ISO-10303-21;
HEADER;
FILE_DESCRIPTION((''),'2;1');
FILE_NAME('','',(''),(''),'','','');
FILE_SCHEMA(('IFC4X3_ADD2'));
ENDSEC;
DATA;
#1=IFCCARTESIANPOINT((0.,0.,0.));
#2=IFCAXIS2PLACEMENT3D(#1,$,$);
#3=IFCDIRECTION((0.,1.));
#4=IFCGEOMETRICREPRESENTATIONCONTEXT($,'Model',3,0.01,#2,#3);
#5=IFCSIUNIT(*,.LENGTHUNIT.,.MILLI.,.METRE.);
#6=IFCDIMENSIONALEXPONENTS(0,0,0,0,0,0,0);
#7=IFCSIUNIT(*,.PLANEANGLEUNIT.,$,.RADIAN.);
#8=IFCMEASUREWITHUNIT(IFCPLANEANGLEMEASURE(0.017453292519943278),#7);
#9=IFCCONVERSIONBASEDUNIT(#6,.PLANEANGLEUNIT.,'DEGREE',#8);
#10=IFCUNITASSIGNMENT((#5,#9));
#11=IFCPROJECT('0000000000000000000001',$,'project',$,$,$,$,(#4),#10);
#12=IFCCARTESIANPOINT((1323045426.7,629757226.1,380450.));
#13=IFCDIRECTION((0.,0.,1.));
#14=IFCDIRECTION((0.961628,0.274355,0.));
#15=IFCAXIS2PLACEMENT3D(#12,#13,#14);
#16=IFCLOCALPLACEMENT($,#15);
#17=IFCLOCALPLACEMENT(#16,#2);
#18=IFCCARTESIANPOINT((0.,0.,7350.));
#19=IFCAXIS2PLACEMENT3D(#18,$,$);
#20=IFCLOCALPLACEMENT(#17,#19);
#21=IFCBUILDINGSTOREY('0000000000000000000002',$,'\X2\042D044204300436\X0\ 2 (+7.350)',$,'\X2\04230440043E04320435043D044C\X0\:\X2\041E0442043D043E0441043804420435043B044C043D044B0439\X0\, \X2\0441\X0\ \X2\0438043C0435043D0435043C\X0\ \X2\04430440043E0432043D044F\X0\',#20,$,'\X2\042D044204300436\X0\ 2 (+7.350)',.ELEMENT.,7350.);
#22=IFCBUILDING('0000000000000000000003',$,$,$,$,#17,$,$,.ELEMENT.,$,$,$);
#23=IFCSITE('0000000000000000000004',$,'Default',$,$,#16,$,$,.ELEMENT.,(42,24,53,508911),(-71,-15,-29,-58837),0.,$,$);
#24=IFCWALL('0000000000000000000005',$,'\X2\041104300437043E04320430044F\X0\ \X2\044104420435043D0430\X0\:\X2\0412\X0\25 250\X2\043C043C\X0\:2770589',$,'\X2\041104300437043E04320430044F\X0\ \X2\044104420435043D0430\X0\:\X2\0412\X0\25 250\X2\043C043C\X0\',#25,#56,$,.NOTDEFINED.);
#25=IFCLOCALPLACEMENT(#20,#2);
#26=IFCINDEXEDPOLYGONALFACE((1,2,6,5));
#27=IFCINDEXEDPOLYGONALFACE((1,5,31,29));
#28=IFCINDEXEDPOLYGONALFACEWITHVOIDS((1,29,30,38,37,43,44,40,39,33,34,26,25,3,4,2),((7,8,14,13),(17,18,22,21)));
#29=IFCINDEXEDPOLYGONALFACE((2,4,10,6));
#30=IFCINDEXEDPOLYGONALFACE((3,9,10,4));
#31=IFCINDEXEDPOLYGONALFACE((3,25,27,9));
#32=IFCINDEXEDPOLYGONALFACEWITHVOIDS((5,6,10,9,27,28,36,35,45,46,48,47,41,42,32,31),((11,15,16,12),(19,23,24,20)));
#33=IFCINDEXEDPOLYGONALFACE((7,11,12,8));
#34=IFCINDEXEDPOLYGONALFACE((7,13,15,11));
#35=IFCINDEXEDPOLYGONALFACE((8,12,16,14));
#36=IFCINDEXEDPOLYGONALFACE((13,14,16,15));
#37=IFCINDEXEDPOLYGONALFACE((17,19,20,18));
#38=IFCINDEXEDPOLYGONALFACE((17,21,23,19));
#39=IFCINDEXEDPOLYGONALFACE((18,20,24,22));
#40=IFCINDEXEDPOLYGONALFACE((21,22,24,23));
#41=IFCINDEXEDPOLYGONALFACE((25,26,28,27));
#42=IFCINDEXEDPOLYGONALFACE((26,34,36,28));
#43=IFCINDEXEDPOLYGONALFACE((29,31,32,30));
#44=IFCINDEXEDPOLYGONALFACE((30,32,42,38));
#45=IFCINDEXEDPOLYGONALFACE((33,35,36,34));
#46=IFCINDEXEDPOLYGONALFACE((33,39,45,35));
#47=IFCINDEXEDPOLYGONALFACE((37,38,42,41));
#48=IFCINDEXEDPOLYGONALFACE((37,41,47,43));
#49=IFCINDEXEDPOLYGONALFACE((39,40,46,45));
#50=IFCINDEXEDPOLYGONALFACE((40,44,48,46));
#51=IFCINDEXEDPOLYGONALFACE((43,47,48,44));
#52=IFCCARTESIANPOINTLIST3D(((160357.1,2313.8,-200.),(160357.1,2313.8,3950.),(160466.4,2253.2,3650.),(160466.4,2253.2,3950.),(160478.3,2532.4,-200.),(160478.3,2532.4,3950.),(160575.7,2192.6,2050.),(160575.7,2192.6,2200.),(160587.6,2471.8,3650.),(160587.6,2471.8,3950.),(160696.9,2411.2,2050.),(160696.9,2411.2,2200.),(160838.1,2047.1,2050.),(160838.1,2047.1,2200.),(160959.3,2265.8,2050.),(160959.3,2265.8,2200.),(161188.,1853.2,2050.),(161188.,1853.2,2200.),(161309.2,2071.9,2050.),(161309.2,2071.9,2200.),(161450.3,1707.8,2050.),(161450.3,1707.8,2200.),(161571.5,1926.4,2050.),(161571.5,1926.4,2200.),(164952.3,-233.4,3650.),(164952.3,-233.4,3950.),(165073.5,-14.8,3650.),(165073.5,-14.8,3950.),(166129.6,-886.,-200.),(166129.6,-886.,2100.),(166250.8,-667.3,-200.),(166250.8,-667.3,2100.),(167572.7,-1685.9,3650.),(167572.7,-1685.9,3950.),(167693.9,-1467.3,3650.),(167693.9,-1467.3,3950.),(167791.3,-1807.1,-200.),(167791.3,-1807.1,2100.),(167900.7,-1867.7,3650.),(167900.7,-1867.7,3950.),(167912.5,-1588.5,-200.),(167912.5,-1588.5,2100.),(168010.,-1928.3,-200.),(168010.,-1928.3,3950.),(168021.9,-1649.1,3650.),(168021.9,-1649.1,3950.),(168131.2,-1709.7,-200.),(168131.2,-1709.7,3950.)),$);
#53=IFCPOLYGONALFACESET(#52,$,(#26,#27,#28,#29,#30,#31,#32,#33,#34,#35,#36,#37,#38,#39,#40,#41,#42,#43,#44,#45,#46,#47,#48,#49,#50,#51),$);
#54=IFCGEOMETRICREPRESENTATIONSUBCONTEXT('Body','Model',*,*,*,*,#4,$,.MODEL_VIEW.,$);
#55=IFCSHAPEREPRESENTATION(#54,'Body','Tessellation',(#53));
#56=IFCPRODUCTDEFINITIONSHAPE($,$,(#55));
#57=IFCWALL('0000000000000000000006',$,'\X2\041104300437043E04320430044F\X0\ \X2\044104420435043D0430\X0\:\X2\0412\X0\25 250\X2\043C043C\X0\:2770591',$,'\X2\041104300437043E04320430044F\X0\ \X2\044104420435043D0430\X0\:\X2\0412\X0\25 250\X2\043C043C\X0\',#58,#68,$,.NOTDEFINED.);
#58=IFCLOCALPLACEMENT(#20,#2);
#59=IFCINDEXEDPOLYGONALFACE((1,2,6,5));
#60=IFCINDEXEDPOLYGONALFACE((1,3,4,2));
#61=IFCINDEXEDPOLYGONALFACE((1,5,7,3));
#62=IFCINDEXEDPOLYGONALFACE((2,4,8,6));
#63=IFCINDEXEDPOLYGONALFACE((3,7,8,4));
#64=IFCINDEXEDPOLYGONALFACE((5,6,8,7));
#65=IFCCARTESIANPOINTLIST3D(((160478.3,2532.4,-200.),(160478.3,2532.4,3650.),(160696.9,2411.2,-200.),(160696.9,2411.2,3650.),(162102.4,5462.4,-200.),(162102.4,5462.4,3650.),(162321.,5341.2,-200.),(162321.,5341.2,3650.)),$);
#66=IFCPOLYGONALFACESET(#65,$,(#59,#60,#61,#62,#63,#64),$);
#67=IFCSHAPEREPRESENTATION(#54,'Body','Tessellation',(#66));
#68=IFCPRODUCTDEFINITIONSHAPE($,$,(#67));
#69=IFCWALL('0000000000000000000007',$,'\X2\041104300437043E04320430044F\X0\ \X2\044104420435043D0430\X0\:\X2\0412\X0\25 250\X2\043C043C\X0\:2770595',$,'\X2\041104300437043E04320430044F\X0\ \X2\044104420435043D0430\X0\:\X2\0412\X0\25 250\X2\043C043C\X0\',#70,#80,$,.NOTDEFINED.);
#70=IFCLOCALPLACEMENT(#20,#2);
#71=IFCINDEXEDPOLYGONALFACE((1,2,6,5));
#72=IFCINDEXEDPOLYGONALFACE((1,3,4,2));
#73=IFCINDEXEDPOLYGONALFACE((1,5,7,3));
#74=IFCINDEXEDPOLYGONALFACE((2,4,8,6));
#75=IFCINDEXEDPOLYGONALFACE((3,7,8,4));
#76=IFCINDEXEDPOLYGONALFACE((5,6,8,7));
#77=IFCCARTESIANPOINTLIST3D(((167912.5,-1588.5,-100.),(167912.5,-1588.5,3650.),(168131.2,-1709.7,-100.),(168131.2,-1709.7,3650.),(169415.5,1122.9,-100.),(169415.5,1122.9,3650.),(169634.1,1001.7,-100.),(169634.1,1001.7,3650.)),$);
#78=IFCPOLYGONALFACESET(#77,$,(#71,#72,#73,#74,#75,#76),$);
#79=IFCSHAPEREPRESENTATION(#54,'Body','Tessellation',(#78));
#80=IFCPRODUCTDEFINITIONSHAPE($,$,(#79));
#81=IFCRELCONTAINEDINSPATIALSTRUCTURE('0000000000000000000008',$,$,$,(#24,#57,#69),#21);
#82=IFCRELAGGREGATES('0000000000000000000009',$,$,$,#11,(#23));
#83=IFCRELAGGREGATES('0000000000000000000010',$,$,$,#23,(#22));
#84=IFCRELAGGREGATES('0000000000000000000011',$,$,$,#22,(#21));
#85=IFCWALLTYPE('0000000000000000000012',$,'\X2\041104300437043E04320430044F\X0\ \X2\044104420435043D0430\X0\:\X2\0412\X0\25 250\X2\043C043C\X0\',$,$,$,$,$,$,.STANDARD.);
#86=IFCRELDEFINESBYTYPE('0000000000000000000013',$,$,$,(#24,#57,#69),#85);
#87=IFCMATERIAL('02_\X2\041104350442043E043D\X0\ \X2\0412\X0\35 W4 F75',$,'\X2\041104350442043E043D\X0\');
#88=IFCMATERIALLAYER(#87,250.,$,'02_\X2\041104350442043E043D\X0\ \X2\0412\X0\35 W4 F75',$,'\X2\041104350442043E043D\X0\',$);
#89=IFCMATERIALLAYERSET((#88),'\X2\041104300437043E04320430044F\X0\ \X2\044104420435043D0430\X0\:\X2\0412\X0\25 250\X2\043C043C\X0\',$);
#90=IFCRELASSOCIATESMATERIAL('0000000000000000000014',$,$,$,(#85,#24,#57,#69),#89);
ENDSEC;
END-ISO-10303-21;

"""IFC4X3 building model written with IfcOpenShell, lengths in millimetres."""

from ifc_helpers import new_model, entity, si_unit, converted_unit, direction, frame, frame_2d, origin, place, context, subcontext, project, spatial, polyline, rectangle, extrude, clip, bounded_halfspace, material, layer, layer_set, type_object, element, save


model = new_model("IFC4X3")

# Units and contexts
model_context = context("Model", 3, precision=0.01, world=origin(), true_north=direction((0.0, 1.0)))
body_context = subcontext(model_context, "Body", "Model", "MODEL_VIEW")
ifc_project = project(units=[si_unit("LENGTHUNIT", "METRE", prefix="MILLI"), converted_unit("PLANEANGLEUNIT", "DEGREE", entity("IfcPlaneAngleMeasure", 0.017453292519943278), si_unit("PLANEANGLEUNIT", "RADIAN"), dimensions=[0, 0, 0, 0, 0, 0, 0])], contexts=[model_context])

# Site, building, storey
site_placement = place(None, frame((1323045426.7, 629757226.1, 380450.0), z_axis=(0.0, 0.0, 1.0), x_axis=(0.961628, 0.274355, 0.0)))
site = spatial("IfcSite", under=ifc_project, at=site_placement, Name="Default", CompositionType="ELEMENT", RefLatitude=(42, 24, 53, 508911), RefLongitude=(-71, -15, -29, -58837), RefElevation=0.0)
building_placement = place(site_placement, origin())
building = spatial("IfcBuilding", under=site, at=building_placement, CompositionType="ELEMENT")
storey_placement = place(building_placement, frame((0.0, 0.0, 7350.0)))
storey = spatial("IfcBuildingStorey", under=building, at=storey_placement, Name="Этаж 2 (+7.350)", ObjectType="Уровень:Относительный, с именем уровня", LongName="Этаж 2 (+7.350)", CompositionType="ELEMENT", Elevation=7350.0)

# Shared definitions
ifc_material = material(Name="02_Бетон В35 W4 F75", Category="Бетон")

# Wall, openings
ifc_layer = layer(ifc_material, 250.0, Name="02_Бетон В35 W4 F75", Category="Бетон")
ifc_layer_set = layer_set([ifc_layer], Name="Базовая стена:В25 250мм")
wall_type = type_object("IfcWallType", Name="Базовая стена:В25 250мм", PredefinedType="STANDARD", material=ifc_layer_set)
wall_1_placement = place(storey_placement, frame((160417.7, 2423.1, -200.0), z_axis=(0.0, 0.0, 1.0), x_axis=(0.87462, -0.48481, 0.0)))
wall_1 = element("IfcWall", 1, at=wall_1_placement, inside=storey, type_object=wall_type, material=ifc_layer_set, Name="Базовая стена:В25 250мм:2770589", ObjectType="Базовая стена:В25 250мм", PredefinedType="NOTDEFINED", context=body_context, shape_type="Clipping", body=[
    clip(extrude(rectangle(XDim=8750.0, YDim=250.0, at=frame_2d((4375.0, 0.0), x_axis=(-1.0, 0.0))), origin(), (0.0, 0.0, 1.0), 4150.0), bounded_halfspace(frame((5254.0, -125.0, 4150.0), z_axis=(0.0, 0.0, -1.0), x_axis=(0.0, -1.0, 0.0)), True, frame((5254.0, -125.0, 4150.0)), polyline([(0.0, 0.0), (1.0, 0.0), (2996.0, 0.0), (2996.0, 250.0), (0.0, 250.0), (0.0, 249.7), (0.0, 0.0)]))),
])
opening_1_placement = place(wall_1_placement, origin())
element("IfcOpeningElement", 2, at=opening_1_placement, cuts=wall_1, PredefinedType="OPENING", context=body_context, shape_type="SweptSolid", body=[
    extrude(rectangle(XDim=300.0, YDim=375.0, at=frame_2d((0.0, 0.0), x_axis=(1.0, 0.0))), frame((8437.5, 125.0, 4000.0), z_axis=(0.0, -1.0, 0.0), x_axis=(0.0, 0.0, 1.0)), (0.0, 0.0, 1.0), 250.0),
])
opening_2_placement = place(wall_1_placement, origin())
element("IfcOpeningElement", 3, at=opening_2_placement, cuts=wall_1, PredefinedType="OPENING", context=body_context, shape_type="SweptSolid", body=[
    extrude(rectangle(XDim=300.0, YDim=5129.0, at=frame_2d((0.0, 0.0), x_axis=(0.0, 1.0))), frame((2689.5, 125.0, 4000.0), z_axis=(0.0, -1.0, 0.0), x_axis=(-1.0, 0.0, 0.0)), (0.0, 0.0, 1.0), 250.0),
])
opening_3_placement = place(wall_1_placement, frame((-139129.7, -79891.3, 0.0), z_axis=(0.0, 0.0, 1.0), x_axis=(0.87462, 0.48481, 0.0)))
element("IfcOpeningElement", 4, at=opening_3_placement, cuts=wall_1, PredefinedType="OPENING", context=body_context, shape_type="SweptSolid", body=[
    extrude(rectangle(XDim=2300.0, YDim=1900.0, at=frame_2d((0.0, 0.0), x_axis=(0.0, 1.0))), frame((166342.8, -2460.8, 1150.0), z_axis=(0.48481, 0.87462, 0.0), x_axis=(0.87462, -0.48481, 0.0)), (0.0, 0.0, 1.0), 3048.0),
])
opening_4_placement = place(wall_1_placement, frame((-139129.7, -79891.3, 2250.0), z_axis=(0.0, 0.0, 1.0), x_axis=(0.87462, 0.48481, 0.0)))
element("IfcOpeningElement", 5, at=opening_4_placement, cuts=wall_1, PredefinedType="OPENING", context=body_context, shape_type="SweptSolid", body=[
    extrude(rectangle(XDim=150.0, YDim=300.0, at=frame_2d((0.0, 0.0), x_axis=(1.0, 0.0))), frame((160089.3, 1005.6, 75.0), z_axis=(0.48481, 0.87462, 0.0), x_axis=(0.0, 0.0, -1.0)), (0.0, 0.0, 1.0), 3048.0),
])
opening_5_placement = place(wall_1_placement, frame((-139129.7, -79891.3, 2250.0), z_axis=(0.0, 0.0, 1.0), x_axis=(0.87462, 0.48481, 0.0)))
element("IfcOpeningElement", 6, at=opening_5_placement, cuts=wall_1, PredefinedType="OPENING", context=body_context, shape_type="SweptSolid", body=[
    extrude(rectangle(XDim=150.0, YDim=300.0, at=frame_2d((0.0, 0.0), x_axis=(1.0, 0.0))), frame((160701.5, 666.2, 75.0), z_axis=(0.48481, 0.87462, 0.0), x_axis=(0.0, 0.0, -1.0)), (0.0, 0.0, 1.0), 3048.0),
])

# Walls
wall_2_placement = place(storey_placement, frame((160587.6, 2471.8, -200.0), z_axis=(0.0, 0.0, 1.0), x_axis=(0.48481, 0.87462, 0.0)))
element("IfcWall", 7, at=wall_2_placement, inside=storey, type_object=wall_type, material=ifc_layer_set, Name="Базовая стена:В25 250мм:2770591", ObjectType="Базовая стена:В25 250мм", PredefinedType="NOTDEFINED", context=body_context, shape_type="SweptSolid", body=[
    extrude(rectangle(XDim=3350.0, YDim=250.0, at=frame_2d((1675.0, 0.0), x_axis=(-1.0, 0.0))), origin(), (0.0, 0.0, 1.0), 3850.0),
])
wall_3_placement = place(storey_placement, frame((168021.9, -1649.1, -100.0), z_axis=(0.0, 0.0, 1.0), x_axis=(0.48481, 0.87462, 0.0)))
element("IfcWall", 8, at=wall_3_placement, inside=storey, type_object=wall_type, material=ifc_layer_set, Name="Базовая стена:В25 250мм:2770595", ObjectType="Базовая стена:В25 250мм", PredefinedType="NOTDEFINED", context=body_context, shape_type="SweptSolid", body=[
    extrude(rectangle(XDim=3100.0, YDim=250.0, at=frame_2d((1550.0, 0.0), x_axis=(-1.0, 0.0))), origin(), (0.0, 0.0, 1.0), 3750.0),
])

save(model, "model.ifc")
